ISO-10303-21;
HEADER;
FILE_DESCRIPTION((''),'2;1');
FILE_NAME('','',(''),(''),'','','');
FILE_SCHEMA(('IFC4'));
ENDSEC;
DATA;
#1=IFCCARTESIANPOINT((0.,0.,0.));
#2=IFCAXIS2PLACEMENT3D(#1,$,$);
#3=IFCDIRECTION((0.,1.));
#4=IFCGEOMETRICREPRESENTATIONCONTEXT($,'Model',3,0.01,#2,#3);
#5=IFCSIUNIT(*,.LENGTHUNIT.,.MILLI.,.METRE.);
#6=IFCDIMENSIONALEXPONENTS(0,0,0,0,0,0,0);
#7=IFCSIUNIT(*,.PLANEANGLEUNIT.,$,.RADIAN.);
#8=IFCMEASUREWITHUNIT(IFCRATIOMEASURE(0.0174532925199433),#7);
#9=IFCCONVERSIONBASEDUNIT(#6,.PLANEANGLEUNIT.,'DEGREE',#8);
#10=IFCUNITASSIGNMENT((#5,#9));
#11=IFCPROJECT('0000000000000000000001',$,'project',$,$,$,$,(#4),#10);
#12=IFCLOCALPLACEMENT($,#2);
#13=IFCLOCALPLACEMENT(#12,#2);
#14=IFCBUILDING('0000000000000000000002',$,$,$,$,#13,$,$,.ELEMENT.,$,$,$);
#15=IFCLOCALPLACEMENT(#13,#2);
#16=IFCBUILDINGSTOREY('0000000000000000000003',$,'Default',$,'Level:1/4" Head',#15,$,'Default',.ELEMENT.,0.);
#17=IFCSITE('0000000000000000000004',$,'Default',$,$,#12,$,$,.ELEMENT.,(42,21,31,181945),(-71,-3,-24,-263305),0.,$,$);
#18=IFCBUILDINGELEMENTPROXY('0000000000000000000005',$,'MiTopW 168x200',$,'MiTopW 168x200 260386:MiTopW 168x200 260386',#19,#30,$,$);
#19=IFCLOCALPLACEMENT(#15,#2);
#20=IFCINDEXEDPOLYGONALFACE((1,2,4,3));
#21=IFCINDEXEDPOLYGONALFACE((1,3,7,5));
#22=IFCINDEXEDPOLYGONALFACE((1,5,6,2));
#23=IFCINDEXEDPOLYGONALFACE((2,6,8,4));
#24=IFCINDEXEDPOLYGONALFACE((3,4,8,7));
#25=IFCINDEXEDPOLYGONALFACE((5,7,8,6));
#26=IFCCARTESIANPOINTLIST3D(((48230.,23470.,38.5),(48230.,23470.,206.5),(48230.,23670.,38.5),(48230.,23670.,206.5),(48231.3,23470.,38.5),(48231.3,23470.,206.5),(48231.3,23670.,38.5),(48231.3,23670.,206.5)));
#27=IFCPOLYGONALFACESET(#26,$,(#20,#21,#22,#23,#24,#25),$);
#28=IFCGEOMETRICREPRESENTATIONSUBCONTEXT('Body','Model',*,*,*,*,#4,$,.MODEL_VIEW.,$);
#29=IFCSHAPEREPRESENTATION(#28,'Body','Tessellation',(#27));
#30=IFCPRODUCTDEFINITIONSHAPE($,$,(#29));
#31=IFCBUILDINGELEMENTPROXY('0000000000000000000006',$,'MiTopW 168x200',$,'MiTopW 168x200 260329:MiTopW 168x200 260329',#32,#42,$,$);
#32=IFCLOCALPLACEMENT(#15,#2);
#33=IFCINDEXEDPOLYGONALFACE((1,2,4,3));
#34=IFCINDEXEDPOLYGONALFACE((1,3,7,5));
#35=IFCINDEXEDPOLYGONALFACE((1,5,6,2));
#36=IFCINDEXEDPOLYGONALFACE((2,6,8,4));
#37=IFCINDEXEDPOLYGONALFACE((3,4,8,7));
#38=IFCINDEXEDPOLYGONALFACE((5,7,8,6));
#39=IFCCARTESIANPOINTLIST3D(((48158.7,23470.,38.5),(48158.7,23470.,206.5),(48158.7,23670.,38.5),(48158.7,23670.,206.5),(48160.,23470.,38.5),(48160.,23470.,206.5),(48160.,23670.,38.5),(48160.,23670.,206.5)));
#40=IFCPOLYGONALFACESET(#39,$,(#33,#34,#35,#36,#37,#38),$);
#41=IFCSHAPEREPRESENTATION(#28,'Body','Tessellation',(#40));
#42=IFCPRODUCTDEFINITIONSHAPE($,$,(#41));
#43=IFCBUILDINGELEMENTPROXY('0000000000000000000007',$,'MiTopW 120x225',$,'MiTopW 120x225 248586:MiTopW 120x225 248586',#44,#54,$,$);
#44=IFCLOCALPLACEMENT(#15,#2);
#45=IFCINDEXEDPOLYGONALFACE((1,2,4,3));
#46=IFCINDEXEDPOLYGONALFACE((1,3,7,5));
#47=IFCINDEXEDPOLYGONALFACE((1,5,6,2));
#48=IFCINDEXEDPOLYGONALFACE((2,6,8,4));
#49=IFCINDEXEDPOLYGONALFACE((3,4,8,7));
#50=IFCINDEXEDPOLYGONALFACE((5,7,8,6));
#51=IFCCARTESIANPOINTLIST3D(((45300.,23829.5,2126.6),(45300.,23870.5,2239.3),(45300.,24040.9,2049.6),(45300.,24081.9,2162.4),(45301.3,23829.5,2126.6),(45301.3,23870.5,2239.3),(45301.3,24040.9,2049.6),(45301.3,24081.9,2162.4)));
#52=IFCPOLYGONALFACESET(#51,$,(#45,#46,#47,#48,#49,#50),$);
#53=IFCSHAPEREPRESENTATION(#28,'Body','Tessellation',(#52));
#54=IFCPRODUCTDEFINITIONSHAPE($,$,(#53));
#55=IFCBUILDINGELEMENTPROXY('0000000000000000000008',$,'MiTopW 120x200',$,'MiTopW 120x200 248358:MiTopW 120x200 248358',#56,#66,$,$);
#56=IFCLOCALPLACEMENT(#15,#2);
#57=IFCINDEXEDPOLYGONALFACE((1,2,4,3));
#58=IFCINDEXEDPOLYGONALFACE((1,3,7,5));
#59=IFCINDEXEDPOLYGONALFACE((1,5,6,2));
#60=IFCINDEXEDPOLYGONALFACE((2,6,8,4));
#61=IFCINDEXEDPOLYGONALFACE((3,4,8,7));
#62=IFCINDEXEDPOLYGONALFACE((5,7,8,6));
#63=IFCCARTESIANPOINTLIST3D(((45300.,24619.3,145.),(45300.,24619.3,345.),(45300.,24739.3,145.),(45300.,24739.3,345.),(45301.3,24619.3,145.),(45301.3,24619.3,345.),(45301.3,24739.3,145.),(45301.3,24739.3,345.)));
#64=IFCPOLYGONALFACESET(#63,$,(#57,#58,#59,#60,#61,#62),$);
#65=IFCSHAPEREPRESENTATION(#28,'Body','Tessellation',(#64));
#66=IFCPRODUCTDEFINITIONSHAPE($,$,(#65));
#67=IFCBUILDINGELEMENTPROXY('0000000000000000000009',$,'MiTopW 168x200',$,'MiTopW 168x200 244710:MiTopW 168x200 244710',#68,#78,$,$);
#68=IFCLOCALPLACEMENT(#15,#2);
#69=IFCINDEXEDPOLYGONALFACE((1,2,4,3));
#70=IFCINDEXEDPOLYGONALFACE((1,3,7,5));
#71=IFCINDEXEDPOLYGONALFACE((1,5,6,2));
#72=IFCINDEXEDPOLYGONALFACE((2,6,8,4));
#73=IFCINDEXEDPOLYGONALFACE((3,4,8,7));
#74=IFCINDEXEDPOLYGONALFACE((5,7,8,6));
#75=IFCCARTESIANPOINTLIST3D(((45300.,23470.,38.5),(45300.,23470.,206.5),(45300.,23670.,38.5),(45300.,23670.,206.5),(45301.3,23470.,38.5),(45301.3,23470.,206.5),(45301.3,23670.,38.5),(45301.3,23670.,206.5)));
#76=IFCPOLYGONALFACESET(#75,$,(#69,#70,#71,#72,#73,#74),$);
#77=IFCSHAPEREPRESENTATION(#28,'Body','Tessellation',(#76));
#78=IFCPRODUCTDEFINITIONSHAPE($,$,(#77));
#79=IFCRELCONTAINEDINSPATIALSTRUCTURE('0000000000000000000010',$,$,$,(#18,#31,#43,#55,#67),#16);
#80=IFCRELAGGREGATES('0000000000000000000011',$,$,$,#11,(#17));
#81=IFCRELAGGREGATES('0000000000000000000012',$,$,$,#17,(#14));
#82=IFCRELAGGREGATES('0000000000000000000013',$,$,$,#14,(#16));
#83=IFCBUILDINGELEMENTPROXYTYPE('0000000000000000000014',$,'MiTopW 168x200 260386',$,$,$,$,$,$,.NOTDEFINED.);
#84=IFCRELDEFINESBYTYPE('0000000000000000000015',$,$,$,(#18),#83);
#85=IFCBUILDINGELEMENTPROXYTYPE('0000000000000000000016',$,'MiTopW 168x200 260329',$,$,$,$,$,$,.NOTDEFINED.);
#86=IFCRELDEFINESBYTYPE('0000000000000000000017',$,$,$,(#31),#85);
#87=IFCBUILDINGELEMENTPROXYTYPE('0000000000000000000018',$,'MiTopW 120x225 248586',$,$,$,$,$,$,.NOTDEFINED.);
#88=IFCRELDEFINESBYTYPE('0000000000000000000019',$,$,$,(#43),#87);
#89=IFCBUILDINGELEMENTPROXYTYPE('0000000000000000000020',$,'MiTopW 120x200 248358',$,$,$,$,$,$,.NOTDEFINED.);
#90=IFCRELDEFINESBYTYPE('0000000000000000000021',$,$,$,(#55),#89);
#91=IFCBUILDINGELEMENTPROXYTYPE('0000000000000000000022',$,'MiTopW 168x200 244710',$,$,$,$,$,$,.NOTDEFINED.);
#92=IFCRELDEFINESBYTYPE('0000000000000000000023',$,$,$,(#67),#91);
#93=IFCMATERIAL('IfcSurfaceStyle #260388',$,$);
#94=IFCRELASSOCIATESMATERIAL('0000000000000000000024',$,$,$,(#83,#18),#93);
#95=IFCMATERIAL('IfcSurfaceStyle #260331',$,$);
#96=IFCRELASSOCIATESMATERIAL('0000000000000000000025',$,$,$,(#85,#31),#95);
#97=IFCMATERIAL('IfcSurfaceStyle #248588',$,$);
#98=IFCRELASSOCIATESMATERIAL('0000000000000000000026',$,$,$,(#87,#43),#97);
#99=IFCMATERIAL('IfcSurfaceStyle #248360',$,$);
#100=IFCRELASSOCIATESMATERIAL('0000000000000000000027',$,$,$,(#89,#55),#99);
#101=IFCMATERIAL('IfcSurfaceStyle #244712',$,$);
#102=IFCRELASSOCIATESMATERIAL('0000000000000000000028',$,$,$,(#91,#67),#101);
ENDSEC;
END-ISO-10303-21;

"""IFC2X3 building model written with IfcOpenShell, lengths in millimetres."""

from ifc_helpers import new_model, entity, si_unit, converted_unit, direction, frame, origin, origin_2d_with_axis, place, context, subcontext, project, spatial, polyline, rectangle, outline, extrude, source, transform, mapped, material, type_object, type_shapes, element, save


model = new_model("IFC2X3")

# Units and contexts
model_context = context("Model", 3, precision=0.01, world=origin(), true_north=direction((0.0, 1.0)))
body_context = subcontext(model_context, "Body", "Model", "MODEL_VIEW")
ifc_project = project(units=[si_unit("LENGTHUNIT", "METRE", prefix="MILLI"), converted_unit("PLANEANGLEUNIT", "DEGREE", entity("IfcRatioMeasure", 0.0174532925199433), si_unit("PLANEANGLEUNIT", "RADIAN"), dimensions=[0, 0, 0, 0, 0, 0, 0])], contexts=[model_context])

# Site, building, storey
site_placement = place(None, origin())
site = spatial("IfcSite", under=ifc_project, at=site_placement, Name="Default", CompositionType="ELEMENT", RefLatitude=(42, 21, 31, 181945), RefLongitude=(-71, -3, -24, -263305), RefElevation=0.0)
building_placement = place(site_placement, origin())
building = spatial("IfcBuilding", under=site, at=building_placement, CompositionType="ELEMENT")
storey_placement = place(building_placement, origin())
storey = spatial("IfcBuildingStorey", under=building, at=storey_placement, Name="Default", ObjectType="Level:1/4\" Head", LongName="Default", CompositionType="ELEMENT", Elevation=0.0)

# Building element proxies
ifc_material_1 = material(Name="IfcSurfaceStyle #260388")
building_element_proxy_type_1 = type_object("IfcBuildingElementProxyType", Name="MiTopW 168x200 260386", PredefinedType="NOTDEFINED", material=ifc_material_1)
shared_shape_1 = source(origin(), body_context, "Body", "SweptSolid", [
    extrude(rectangle(XDim=200.0, YDim=168.0, at=origin_2d_with_axis()), frame((100.0, 84.0, 0.0), z_axis=(0.0, 0.0, 1.0), x_axis=(-1.0, 0.0, 0.0)), (0.0, 0.0, 1.0), 1.3),
])
type_shapes(building_element_proxy_type_1, [shared_shape_1])
proxy_1_placement = place(building_placement, frame((48231.3, 23470.0, 206.5), z_axis=(-1.0, 0.0, 0.0), x_axis=(0.0, 1.0, 0.0)))
element("IfcBuildingElementProxy", 1, at=proxy_1_placement, inside=storey, type_object=building_element_proxy_type_1, material=ifc_material_1, Name="MiTopW 168x200", ObjectType="MiTopW 168x200 260386:MiTopW 168x200 260386", context=body_context, shape_type="MappedRepresentation", body=[
    mapped(shared_shape_1, transform((0.0, 0.0, 0.0), scale=1.0)),
])
ifc_material_2 = material(Name="IfcSurfaceStyle #260331")
building_element_proxy_type_2 = type_object("IfcBuildingElementProxyType", Name="MiTopW 168x200 260329", PredefinedType="NOTDEFINED", material=ifc_material_2)
shared_shape_2 = source(origin(), body_context, "Body", "SweptSolid", [
    extrude(rectangle(XDim=200.0, YDim=168.0, at=origin_2d_with_axis()), frame((100.0, 84.0, 0.0), z_axis=(0.0, 0.0, 1.0), x_axis=(-1.0, 0.0, 0.0)), (0.0, 0.0, 1.0), 1.3),
])
type_shapes(building_element_proxy_type_2, [shared_shape_2])
proxy_2_placement = place(building_placement, frame((48160.0, 23470.0, 206.5), z_axis=(-1.0, 0.0, 0.0), x_axis=(0.0, 1.0, 0.0)))
element("IfcBuildingElementProxy", 2, at=proxy_2_placement, inside=storey, type_object=building_element_proxy_type_2, material=ifc_material_2, Name="MiTopW 168x200", ObjectType="MiTopW 168x200 260329:MiTopW 168x200 260329", context=body_context, shape_type="MappedRepresentation", body=[
    mapped(shared_shape_2, transform((0.0, 0.0, 0.0), scale=1.0)),
])
ifc_material_3 = material(Name="IfcSurfaceStyle #248588")
building_element_proxy_type_3 = type_object("IfcBuildingElementProxyType", Name="MiTopW 120x225 248586", PredefinedType="NOTDEFINED", material=ifc_material_3)
shared_shape_3 = source(origin(), body_context, "Body", "SweptSolid", [
    extrude(outline(polyline([(-112.5, -60.0), (112.5, -60.0), (112.5, 60.0), (-112.5, 60.0), (-112.5, -60.0)])), frame((112.5, 60.0, 0.0), z_axis=(0.0, 0.0, 1.0), x_axis=(-1.0, 0.0, 0.0)), (0.0, 0.0, 1.0), 1.3),
])
type_shapes(building_element_proxy_type_3, [shared_shape_3])
proxy_3_placement = place(building_placement, frame((45301.3, 24040.9, 2049.6), z_axis=(-1.0, 0.0, 0.0), x_axis=(0.0, -0.939693, 0.34202)))
element("IfcBuildingElementProxy", 3, at=proxy_3_placement, inside=storey, type_object=building_element_proxy_type_3, material=ifc_material_3, Name="MiTopW 120x225", ObjectType="MiTopW 120x225 248586:MiTopW 120x225 248586", context=body_context, shape_type="MappedRepresentation", body=[
    mapped(shared_shape_3, transform((0.0, 0.0, 0.0), scale=1.0)),
])
ifc_material_4 = material(Name="IfcSurfaceStyle #248360")
building_element_proxy_type_4 = type_object("IfcBuildingElementProxyType", Name="MiTopW 120x200 248358", PredefinedType="NOTDEFINED", material=ifc_material_4)
shared_shape_4 = source(origin(), body_context, "Body", "SweptSolid", [
    extrude(rectangle(XDim=200.0, YDim=120.0, at=origin_2d_with_axis()), frame((100.0, 60.0, 0.0), z_axis=(0.0, 0.0, 1.0), x_axis=(-1.0, 0.0, 0.0)), (0.0, 0.0, 1.0), 1.3),
])
type_shapes(building_element_proxy_type_4, [shared_shape_4])
proxy_4_placement = place(building_placement, frame((45301.3, 24619.3, 145.0), z_axis=(-1.0, 0.0, 0.0), x_axis=(0.0, 0.0, 1.0)))
element("IfcBuildingElementProxy", 4, at=proxy_4_placement, inside=storey, type_object=building_element_proxy_type_4, material=ifc_material_4, Name="MiTopW 120x200", ObjectType="MiTopW 120x200 248358:MiTopW 120x200 248358", context=body_context, shape_type="MappedRepresentation", body=[
    mapped(shared_shape_4, transform((0.0, 0.0, 0.0), scale=1.0)),
])
ifc_material_5 = material(Name="IfcSurfaceStyle #244712")
building_element_proxy_type_5 = type_object("IfcBuildingElementProxyType", Name="MiTopW 168x200 244710", PredefinedType="NOTDEFINED", material=ifc_material_5)
shared_shape_5 = source(origin(), body_context, "Body", "SweptSolid", [
    extrude(rectangle(XDim=200.0, YDim=168.0, at=origin_2d_with_axis()), frame((100.0, 84.0, 0.0), z_axis=(0.0, 0.0, 1.0), x_axis=(-1.0, 0.0, 0.0)), (0.0, 0.0, 1.0), 1.3),
])
type_shapes(building_element_proxy_type_5, [shared_shape_5])
proxy_5_placement = place(building_placement, frame((45301.3, 23470.0, 206.5), z_axis=(-1.0, 0.0, 0.0), x_axis=(0.0, 1.0, 0.0)))
element("IfcBuildingElementProxy", 5, at=proxy_5_placement, inside=storey, type_object=building_element_proxy_type_5, material=ifc_material_5, Name="MiTopW 168x200", ObjectType="MiTopW 168x200 244710:MiTopW 168x200 244710", context=body_context, shape_type="MappedRepresentation", body=[
    mapped(shared_shape_5, transform((0.0, 0.0, 0.0), scale=1.0)),
])

save(model, "model.ifc")
